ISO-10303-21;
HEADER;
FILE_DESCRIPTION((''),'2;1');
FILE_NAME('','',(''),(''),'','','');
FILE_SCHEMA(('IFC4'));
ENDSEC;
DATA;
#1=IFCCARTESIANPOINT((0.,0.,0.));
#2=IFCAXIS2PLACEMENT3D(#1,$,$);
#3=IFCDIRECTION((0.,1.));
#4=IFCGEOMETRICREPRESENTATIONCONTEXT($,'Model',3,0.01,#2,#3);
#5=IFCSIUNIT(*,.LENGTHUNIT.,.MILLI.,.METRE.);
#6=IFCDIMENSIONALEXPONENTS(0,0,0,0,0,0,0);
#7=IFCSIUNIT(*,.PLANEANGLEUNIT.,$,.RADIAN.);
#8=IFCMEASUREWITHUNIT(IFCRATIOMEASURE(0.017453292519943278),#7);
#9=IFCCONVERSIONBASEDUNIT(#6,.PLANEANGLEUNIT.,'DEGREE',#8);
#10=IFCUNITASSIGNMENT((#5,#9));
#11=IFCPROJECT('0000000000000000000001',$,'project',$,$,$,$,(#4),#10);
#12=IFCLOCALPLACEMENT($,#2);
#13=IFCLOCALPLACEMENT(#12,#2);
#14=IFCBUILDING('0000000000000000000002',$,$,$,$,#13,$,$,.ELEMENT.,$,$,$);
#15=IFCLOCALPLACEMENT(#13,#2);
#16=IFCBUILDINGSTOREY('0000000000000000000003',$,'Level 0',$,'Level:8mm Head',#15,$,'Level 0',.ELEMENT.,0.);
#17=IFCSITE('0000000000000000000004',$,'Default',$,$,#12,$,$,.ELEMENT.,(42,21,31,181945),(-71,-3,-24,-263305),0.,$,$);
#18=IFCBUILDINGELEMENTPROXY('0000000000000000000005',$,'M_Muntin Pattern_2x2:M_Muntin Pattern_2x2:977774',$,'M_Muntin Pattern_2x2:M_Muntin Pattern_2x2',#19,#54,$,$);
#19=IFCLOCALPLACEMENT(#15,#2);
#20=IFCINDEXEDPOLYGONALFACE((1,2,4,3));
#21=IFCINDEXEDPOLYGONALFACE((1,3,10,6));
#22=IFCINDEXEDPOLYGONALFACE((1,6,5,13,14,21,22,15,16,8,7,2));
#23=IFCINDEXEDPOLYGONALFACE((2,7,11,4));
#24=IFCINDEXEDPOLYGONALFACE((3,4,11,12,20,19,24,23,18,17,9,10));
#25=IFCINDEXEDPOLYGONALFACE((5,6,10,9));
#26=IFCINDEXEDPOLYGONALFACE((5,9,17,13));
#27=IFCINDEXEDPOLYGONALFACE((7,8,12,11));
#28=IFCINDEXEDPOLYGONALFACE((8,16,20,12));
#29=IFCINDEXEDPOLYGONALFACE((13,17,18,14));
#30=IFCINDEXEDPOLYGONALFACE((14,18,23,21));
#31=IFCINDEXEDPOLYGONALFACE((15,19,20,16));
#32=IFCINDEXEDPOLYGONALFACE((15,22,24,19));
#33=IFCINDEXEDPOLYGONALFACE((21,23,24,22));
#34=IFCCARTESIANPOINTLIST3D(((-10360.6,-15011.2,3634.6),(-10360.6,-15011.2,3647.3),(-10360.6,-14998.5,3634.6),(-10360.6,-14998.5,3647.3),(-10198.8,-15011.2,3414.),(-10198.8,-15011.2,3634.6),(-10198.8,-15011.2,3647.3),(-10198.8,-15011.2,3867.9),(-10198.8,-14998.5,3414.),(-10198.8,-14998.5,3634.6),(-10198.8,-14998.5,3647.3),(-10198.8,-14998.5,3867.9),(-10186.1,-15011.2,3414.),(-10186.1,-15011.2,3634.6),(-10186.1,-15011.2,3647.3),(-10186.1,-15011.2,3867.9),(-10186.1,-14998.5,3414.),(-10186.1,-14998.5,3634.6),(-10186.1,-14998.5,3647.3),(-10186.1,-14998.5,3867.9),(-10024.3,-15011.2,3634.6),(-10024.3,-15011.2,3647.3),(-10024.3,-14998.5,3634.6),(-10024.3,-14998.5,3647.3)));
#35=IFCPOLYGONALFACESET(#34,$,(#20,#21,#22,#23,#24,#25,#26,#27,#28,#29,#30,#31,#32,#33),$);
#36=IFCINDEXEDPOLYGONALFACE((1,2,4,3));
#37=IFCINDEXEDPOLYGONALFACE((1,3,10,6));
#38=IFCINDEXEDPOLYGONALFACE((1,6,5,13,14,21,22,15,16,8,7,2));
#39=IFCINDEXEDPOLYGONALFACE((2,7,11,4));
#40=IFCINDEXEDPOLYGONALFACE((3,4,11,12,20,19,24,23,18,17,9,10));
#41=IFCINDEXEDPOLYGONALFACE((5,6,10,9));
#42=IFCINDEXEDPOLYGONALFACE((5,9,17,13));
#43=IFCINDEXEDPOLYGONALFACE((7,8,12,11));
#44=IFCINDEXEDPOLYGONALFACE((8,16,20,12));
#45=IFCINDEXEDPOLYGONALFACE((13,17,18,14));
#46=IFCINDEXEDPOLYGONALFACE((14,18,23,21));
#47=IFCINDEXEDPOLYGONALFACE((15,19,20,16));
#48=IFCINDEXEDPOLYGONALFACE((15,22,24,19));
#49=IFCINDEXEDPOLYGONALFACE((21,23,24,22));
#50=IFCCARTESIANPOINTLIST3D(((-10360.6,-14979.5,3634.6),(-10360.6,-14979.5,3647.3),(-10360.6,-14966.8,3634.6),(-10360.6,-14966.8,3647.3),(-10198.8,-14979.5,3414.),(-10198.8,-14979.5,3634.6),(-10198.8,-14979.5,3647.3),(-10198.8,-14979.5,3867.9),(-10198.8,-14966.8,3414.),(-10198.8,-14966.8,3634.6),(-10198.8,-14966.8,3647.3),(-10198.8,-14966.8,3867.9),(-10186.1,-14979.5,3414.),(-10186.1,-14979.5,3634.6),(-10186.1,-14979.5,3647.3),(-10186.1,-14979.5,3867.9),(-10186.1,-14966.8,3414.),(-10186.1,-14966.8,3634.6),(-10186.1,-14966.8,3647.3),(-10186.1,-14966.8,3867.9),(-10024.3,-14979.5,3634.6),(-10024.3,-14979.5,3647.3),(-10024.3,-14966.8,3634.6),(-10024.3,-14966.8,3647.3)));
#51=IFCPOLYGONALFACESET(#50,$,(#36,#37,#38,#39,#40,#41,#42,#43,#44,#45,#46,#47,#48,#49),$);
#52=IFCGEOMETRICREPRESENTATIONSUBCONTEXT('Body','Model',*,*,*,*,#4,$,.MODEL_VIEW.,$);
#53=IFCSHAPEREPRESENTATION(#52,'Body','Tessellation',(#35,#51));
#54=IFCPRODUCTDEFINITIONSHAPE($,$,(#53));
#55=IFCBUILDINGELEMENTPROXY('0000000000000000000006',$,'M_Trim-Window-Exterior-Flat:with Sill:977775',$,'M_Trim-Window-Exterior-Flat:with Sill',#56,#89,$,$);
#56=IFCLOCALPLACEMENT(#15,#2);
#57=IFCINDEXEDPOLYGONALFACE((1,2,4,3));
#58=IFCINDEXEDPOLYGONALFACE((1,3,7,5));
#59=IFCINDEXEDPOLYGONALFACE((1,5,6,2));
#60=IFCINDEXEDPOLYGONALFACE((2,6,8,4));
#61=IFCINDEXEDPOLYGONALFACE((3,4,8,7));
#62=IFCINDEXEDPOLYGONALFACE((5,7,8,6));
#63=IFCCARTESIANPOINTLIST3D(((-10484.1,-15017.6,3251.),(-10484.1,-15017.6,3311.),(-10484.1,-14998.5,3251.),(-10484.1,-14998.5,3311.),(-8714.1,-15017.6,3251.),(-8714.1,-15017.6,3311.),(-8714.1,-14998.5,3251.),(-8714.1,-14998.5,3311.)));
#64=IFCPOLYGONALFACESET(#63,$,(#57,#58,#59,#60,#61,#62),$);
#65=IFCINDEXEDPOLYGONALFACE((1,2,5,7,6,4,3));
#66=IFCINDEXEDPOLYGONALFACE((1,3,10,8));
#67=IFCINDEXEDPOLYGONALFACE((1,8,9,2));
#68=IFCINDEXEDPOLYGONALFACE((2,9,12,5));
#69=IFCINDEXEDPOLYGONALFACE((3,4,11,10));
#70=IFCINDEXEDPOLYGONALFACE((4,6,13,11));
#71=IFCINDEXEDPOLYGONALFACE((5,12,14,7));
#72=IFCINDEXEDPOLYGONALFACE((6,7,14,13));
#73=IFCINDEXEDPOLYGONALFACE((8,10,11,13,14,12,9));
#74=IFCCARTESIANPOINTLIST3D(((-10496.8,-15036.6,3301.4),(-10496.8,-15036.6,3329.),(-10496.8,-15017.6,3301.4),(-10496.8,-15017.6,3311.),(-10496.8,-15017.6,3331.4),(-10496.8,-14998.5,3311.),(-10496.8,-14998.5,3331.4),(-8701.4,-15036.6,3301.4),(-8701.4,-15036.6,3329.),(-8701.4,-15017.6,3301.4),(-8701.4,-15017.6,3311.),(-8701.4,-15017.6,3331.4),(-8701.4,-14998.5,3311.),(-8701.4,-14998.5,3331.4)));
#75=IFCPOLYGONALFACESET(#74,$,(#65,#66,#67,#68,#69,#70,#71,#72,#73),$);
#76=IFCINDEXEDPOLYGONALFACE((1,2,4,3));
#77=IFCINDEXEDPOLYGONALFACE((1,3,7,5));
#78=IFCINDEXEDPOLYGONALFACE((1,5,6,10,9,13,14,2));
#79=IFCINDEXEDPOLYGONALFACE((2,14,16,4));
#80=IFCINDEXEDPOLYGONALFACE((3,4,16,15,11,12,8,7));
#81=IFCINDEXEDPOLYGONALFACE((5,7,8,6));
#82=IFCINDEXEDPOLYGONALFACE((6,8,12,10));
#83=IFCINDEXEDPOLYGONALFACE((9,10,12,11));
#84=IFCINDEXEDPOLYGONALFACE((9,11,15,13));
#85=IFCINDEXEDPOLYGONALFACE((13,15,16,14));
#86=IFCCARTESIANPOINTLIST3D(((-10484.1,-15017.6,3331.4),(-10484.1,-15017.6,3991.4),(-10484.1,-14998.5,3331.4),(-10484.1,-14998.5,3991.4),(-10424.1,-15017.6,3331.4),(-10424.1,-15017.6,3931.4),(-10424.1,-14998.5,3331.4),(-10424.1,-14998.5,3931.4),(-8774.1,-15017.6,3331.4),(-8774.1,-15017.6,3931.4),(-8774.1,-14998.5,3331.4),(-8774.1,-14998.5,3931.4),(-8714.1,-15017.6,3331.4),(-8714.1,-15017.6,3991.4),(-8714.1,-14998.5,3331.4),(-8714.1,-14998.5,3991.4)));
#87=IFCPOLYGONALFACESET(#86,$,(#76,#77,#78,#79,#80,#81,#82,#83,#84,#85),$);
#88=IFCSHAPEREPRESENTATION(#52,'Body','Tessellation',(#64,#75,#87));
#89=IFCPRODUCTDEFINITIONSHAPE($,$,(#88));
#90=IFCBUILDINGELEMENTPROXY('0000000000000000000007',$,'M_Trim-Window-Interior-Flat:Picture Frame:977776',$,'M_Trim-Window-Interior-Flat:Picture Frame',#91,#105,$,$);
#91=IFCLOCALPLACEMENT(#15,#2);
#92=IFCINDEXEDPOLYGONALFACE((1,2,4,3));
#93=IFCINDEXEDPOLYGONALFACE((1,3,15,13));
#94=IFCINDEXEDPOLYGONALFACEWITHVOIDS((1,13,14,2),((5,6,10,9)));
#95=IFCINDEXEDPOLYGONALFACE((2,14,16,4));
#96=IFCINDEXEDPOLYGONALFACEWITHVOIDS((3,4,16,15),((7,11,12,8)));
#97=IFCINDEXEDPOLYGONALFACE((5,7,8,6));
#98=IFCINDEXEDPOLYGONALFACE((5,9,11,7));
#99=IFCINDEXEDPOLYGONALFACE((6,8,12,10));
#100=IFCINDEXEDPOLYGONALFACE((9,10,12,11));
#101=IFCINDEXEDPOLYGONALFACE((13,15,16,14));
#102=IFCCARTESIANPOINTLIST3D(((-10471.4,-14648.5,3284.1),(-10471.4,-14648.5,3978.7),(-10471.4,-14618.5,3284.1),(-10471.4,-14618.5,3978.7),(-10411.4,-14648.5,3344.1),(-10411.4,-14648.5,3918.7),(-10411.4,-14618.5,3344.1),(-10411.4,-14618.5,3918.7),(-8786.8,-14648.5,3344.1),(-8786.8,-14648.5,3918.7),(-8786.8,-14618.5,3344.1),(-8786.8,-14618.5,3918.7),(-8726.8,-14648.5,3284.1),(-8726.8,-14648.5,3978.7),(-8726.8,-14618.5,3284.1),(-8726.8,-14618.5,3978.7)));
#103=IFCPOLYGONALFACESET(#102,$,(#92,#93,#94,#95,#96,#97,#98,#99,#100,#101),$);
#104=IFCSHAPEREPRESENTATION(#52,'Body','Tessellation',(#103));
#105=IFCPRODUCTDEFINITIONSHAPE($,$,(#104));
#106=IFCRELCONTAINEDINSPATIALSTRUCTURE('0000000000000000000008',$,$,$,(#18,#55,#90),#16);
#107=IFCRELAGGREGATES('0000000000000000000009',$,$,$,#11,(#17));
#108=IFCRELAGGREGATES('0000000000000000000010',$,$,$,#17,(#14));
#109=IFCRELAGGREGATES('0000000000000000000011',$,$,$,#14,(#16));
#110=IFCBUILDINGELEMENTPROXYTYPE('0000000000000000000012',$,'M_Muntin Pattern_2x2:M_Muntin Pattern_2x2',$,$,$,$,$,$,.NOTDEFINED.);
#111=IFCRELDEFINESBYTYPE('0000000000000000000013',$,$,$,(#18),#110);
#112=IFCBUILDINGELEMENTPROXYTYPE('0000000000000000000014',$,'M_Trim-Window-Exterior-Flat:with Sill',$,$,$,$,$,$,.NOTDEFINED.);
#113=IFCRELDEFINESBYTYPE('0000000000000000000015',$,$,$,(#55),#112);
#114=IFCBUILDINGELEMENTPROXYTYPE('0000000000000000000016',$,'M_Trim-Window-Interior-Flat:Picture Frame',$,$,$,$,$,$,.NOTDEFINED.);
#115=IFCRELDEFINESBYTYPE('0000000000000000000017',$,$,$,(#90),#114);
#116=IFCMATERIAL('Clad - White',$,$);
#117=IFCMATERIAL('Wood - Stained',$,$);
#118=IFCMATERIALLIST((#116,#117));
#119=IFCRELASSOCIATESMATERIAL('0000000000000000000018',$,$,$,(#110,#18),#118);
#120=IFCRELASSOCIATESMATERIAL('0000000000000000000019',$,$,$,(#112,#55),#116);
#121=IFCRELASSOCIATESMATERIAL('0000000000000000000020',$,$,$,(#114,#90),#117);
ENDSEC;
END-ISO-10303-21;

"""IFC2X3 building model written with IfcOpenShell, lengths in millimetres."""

from ifc_helpers import new_model, entity, si_unit, converted_unit, direction, frame, frame_2d, origin, place, context, subcontext, project, spatial, polyline, rectangle, outline, extrude, source, transform, mapped, material, material_list, type_object, type_shapes, element, save


model = new_model("IFC2X3")

# Units and contexts
model_context = context("Model", 3, precision=0.01, world=origin(), true_north=direction((0.0, 1.0)))
body_context = subcontext(model_context, "Body", "Model", "MODEL_VIEW")
ifc_project = project(units=[si_unit("LENGTHUNIT", "METRE", prefix="MILLI"), converted_unit("PLANEANGLEUNIT", "DEGREE", entity("IfcRatioMeasure", 0.017453292519943278), si_unit("PLANEANGLEUNIT", "RADIAN"), dimensions=[0, 0, 0, 0, 0, 0, 0])], contexts=[model_context])

# Site, building, storey
site_placement = place(None, origin())
site = spatial("IfcSite", under=ifc_project, at=site_placement, Name="Default", CompositionType="ELEMENT", RefLatitude=(42, 21, 31, 181945), RefLongitude=(-71, -3, -24, -263305), RefElevation=0.0)
building_placement = place(site_placement, origin())
building = spatial("IfcBuilding", under=site, at=building_placement, CompositionType="ELEMENT")
storey_placement = place(building_placement, origin())
storey = spatial("IfcBuildingStorey", under=building, at=storey_placement, Name="Level 0", ObjectType="Level:8mm Head", LongName="Level 0", CompositionType="ELEMENT", Elevation=0.0)

# Building element proxies
ifc_material_1 = material(Name="Clad - White")
ifc_material_2 = material(Name="Wood - Stained")
ifc_material_list_1 = material_list([ifc_material_1, ifc_material_2])
building_element_proxy_type_1 = type_object("IfcBuildingElementProxyType", Name="M_Muntin Pattern_2x2:M_Muntin Pattern_2x2", PredefinedType="NOTDEFINED", material=ifc_material_list_1)
shared_shape_1 = source(origin(), body_context, "Body", "SweptSolid", [
    extrude(outline(polyline([(6.4, -6.4), (227.0, -6.4), (227.0, 6.3), (6.4, 6.3), (6.4, 168.2), (-6.3, 168.2), (-6.3, 6.3), (-227.0, 6.3), (-227.0, -6.4), (-6.3, -6.4), (-6.3, -168.1), (6.4, -168.1), (6.4, -6.4)])), frame((0.0, 9.5, 227.0), z_axis=(0.0, 1.0, 0.0), x_axis=(0.0, 0.0, 1.0)), (0.0, 0.0, 1.0), 12.7),
    extrude(outline(polyline([(6.4, -6.4), (227.0, -6.4), (227.0, 6.3), (6.4, 6.3), (6.4, 168.2), (-6.3, 168.2), (-6.3, 6.3), (-227.0, 6.3), (-227.0, -6.4), (-6.3, -6.4), (-6.3, -168.1), (6.4, -168.1), (6.4, -6.4)])), frame((0.0, -22.2, 227.0), z_axis=(0.0, 1.0, 0.0), x_axis=(0.0, 0.0, 1.0)), (0.0, 0.0, 1.0), 12.7),
])
type_shapes(building_element_proxy_type_1, [shared_shape_1])
for number, where, z_axis, x_axis, name in (
    (1, (-10192.4, -14989.0, 3414.0), (0.0, 0.0, 1.0), (-1.0, 0.0, 0.0), "M_Muntin Pattern_2x2:M_Muntin Pattern_2x2:977774"),
):
    element("IfcBuildingElementProxy", number, at=place(storey_placement, frame(where, z_axis=z_axis, x_axis=x_axis)), inside=storey, type_object=building_element_proxy_type_1, material=ifc_material_list_1, Name=name, ObjectType="M_Muntin Pattern_2x2:M_Muntin Pattern_2x2", context=body_context, shape_type="MappedRepresentation", body=[
        mapped(shared_shape_1, transform((0.0, 0.0, 0.0), scale=1.0)),
    ])
building_element_proxy_type_2 = type_object("IfcBuildingElementProxyType", Name="M_Trim-Window-Exterior-Flat:with Sill", PredefinedType="NOTDEFINED", material=ifc_material_1)
shared_shape_2 = source(origin(), body_context, "Body", "SweptSolid", [
    extrude(rectangle(XDim=1770.0, YDim=60.0, at=frame_2d((0.0, 0.0), x_axis=(1.0, 0.0))), frame((0.0, -650.4, 0.0), z_axis=(0.0, 0.0, 1.0), x_axis=(-1.0, 0.0, 0.0)), (0.0, 0.0, 1.0), 19.0),
    extrude(outline(polyline([(-19.0, -15.2), (0.0, -15.2), (0.0, -5.7), (19.0, -5.7), (19.0, 14.8), (0.0, 14.8), (-19.0, 12.3), (-19.0, -15.2)])), frame((-897.7, -614.8, 19.0), z_axis=(1.0, 0.0, 0.0), x_axis=(0.0, 0.0, -1.0)), (0.0, 0.0, 1.0), 1795.4),
    extrude(outline(polyline([(-345.0, -885.0), (315.0, -885.0), (315.0, -825.0), (-285.0, -825.0), (-285.0, 825.0), (315.0, 825.0), (315.0, 885.0), (-345.0, 885.0), (-345.0, -885.0)])), frame((0.0, -285.0, 0.0), z_axis=(0.0, 0.0, 1.0), x_axis=(0.0, -1.0, 0.0)), (0.0, 0.0, 1.0), 19.0),
])
type_shapes(building_element_proxy_type_2, [shared_shape_2])
proxy_1_placement = place(storey_placement, frame((-9599.1, -14998.5, 3931.4), z_axis=(0.0, -1.0, 0.0), x_axis=(1.0, 0.0, 0.0)))
element("IfcBuildingElementProxy", 2, at=proxy_1_placement, inside=storey, type_object=building_element_proxy_type_2, material=ifc_material_1, Name="M_Trim-Window-Exterior-Flat:with Sill:977775", ObjectType="M_Trim-Window-Exterior-Flat:with Sill", context=body_context, shape_type="MappedRepresentation", body=[
    mapped(shared_shape_2, transform((0.0, 0.0, 0.0), scale=1.0)),
])
building_element_proxy_type_3 = type_object("IfcBuildingElementProxyType", Name="M_Trim-Window-Interior-Flat:Picture Frame", PredefinedType="NOTDEFINED", material=ifc_material_2)
shared_shape_3 = source(origin(), body_context, "Body", "SweptSolid", [
    extrude(outline(polyline([(-872.3, -347.3), (872.3, -347.3), (872.3, 347.3), (-872.3, 347.3), (-872.3, -347.3)]), holes=[polyline([(-812.3, -287.3), (-812.3, 287.3), (812.3, 287.3), (812.3, -287.3), (-812.3, -287.3)])]), frame((0.0, -300.0, 0.0), z_axis=(0.0, 0.0, 1.0), x_axis=(-1.0, 0.0, 0.0)), (0.0, 0.0, 1.0), 30.0),
])
type_shapes(building_element_proxy_type_3, [shared_shape_3])
proxy_2_placement = place(storey_placement, frame((-9599.1, -14648.5, 3931.4), z_axis=(0.0, 1.0, 0.0), x_axis=(-1.0, 0.0, 0.0)))
element("IfcBuildingElementProxy", 3, at=proxy_2_placement, inside=storey, type_object=building_element_proxy_type_3, material=ifc_material_2, Name="M_Trim-Window-Interior-Flat:Picture Frame:977776", ObjectType="M_Trim-Window-Interior-Flat:Picture Frame", context=body_context, shape_type="MappedRepresentation", body=[
    mapped(shared_shape_3, transform((0.0, 0.0, 0.0), scale=1.0)),
])

save(model, "model.ifc")
